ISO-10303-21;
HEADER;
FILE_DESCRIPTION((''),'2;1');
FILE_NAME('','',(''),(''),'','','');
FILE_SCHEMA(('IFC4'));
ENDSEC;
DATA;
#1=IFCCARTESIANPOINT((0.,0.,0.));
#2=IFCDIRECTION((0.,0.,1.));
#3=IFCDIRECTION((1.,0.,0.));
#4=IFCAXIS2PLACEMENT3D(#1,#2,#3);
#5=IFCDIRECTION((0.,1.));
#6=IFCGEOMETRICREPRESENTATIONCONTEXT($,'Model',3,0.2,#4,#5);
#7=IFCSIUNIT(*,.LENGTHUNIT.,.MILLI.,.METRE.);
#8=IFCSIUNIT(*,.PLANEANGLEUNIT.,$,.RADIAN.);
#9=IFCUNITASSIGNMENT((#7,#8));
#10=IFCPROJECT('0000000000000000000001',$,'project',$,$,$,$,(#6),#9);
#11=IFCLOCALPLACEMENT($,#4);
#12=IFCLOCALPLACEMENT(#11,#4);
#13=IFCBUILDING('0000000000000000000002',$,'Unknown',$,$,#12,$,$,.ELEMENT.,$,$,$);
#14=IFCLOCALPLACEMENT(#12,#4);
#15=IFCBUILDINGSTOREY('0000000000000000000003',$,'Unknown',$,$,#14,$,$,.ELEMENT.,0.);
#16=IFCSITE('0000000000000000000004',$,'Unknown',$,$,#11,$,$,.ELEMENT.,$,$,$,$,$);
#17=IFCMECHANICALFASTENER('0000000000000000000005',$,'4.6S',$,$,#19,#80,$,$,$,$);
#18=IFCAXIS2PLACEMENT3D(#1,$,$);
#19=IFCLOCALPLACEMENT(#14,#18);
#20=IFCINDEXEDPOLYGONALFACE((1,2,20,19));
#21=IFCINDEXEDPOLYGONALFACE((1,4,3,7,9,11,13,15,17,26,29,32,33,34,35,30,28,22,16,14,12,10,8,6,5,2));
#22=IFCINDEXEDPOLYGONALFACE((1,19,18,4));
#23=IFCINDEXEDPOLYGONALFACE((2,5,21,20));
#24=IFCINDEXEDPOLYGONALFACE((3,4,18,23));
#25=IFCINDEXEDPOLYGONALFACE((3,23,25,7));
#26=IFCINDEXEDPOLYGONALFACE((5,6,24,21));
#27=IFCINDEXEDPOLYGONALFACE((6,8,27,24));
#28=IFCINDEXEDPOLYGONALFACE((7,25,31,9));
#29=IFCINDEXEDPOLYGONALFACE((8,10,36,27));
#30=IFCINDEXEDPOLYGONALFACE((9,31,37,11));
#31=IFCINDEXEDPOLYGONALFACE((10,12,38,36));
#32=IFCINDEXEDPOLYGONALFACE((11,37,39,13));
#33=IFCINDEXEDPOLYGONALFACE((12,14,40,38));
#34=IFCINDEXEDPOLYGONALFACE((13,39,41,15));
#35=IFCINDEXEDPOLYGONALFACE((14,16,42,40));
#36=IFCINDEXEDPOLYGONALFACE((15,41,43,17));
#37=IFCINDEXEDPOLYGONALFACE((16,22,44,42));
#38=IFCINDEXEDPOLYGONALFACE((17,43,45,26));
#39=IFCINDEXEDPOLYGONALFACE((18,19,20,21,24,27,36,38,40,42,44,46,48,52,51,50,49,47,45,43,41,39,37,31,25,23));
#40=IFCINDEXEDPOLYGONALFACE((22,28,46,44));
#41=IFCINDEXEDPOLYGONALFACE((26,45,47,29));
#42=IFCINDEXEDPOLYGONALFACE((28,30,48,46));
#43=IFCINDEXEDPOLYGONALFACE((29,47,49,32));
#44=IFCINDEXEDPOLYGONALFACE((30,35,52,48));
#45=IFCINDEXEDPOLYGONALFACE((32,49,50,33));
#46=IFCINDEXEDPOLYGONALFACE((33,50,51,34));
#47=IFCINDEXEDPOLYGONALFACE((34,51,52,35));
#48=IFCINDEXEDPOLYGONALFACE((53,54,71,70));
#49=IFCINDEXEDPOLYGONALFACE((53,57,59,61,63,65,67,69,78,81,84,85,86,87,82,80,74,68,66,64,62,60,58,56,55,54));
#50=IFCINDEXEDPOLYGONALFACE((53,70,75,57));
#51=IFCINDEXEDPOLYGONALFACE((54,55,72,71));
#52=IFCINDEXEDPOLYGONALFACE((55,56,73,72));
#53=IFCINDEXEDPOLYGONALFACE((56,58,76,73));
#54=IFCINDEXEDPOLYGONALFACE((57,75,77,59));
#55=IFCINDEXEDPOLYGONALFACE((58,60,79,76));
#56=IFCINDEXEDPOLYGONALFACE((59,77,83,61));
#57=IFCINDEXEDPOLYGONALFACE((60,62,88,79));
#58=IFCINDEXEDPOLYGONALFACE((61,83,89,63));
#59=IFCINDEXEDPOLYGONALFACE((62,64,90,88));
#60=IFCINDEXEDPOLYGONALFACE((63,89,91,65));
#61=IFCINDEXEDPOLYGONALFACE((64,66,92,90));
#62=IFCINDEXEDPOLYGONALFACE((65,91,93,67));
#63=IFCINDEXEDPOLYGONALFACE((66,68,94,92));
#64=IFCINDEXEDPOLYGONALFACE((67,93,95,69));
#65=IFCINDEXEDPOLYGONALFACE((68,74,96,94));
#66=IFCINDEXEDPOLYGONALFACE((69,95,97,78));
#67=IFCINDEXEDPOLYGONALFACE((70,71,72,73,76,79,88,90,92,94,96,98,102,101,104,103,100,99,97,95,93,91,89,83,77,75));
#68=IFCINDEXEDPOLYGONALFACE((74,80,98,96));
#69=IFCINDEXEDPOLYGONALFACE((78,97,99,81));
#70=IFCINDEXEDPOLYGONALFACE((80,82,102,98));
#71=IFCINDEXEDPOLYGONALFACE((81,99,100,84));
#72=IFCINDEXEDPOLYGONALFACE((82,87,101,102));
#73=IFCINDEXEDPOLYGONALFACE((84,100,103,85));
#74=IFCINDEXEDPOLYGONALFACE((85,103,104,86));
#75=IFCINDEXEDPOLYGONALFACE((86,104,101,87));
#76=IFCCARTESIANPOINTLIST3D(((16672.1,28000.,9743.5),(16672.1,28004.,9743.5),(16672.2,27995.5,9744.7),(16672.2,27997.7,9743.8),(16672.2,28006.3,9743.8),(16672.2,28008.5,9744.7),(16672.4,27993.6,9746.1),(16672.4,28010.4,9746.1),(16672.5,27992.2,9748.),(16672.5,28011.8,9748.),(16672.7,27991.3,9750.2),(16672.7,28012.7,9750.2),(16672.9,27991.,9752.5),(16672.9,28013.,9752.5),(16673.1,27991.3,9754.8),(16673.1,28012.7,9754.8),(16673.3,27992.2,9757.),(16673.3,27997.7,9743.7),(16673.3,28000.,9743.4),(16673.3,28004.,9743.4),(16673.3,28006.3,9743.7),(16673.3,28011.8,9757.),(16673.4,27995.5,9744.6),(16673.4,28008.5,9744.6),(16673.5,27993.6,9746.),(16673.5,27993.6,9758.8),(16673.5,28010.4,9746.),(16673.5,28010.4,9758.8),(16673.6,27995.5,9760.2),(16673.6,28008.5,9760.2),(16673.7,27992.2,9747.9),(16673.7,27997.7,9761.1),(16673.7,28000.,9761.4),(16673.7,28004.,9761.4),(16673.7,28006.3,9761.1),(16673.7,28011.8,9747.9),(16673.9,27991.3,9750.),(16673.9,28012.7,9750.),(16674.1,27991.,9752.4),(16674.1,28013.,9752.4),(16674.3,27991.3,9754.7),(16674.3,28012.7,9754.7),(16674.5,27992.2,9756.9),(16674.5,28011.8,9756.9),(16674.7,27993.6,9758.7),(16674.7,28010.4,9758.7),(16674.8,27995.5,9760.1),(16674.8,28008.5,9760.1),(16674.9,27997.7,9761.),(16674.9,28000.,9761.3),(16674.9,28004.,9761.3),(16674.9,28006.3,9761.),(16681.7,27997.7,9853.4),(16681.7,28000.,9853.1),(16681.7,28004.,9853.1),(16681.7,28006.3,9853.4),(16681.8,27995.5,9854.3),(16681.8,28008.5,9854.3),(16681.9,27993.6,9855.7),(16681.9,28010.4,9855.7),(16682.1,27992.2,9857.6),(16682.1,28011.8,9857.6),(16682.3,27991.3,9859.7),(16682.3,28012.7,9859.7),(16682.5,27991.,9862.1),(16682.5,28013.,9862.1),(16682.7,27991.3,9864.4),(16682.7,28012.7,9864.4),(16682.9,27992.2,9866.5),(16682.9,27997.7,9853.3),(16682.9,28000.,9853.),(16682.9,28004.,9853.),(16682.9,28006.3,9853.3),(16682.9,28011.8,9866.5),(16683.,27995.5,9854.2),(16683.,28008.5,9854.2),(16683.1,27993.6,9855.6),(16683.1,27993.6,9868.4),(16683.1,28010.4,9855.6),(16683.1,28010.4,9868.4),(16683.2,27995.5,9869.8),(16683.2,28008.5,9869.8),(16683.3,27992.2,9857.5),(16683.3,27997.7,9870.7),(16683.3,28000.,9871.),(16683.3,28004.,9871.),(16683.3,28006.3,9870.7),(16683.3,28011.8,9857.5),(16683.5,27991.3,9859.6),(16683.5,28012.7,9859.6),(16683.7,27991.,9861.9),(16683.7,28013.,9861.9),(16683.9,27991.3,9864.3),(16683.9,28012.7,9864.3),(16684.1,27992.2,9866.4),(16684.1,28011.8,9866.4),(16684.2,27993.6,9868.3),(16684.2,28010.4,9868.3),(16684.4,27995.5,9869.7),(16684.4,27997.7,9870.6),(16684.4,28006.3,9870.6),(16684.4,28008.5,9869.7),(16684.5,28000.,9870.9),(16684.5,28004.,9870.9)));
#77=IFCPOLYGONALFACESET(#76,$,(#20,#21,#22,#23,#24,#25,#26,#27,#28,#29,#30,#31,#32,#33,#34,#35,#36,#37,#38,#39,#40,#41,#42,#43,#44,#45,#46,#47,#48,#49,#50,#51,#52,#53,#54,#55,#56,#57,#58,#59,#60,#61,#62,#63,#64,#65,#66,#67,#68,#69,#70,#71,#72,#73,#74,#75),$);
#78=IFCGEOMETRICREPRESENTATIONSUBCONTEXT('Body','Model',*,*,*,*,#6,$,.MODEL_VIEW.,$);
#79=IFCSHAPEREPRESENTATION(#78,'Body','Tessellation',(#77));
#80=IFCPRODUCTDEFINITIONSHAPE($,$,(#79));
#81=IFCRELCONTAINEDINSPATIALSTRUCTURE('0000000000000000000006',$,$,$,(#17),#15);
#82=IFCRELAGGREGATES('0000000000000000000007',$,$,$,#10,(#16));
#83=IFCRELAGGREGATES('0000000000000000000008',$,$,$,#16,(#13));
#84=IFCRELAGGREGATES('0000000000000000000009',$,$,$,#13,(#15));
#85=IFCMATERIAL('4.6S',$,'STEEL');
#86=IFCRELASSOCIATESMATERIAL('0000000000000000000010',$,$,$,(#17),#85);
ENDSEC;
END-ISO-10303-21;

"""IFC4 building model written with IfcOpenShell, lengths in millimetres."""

from ifc_helpers import new_model, si_unit, direction, frame, origin_with_axes, place, context, subcontext, project, spatial, line, arc, indexed_curve, outline, extrude, source, transform, mapped, material, element, save


model = new_model("IFC4")

# Units and contexts
model_context = context("Model", 3, precision=0.2, world=origin_with_axes(), true_north=direction((0.0, 1.0)))
body_context = subcontext(model_context, "Body", "Model", "MODEL_VIEW")
ifc_project = project(units=[si_unit("LENGTHUNIT", "METRE", prefix="MILLI"), si_unit("PLANEANGLEUNIT", "RADIAN")], contexts=[model_context])

# Site, building, storey
site_placement = place(None, origin_with_axes())
site = spatial("IfcSite", under=ifc_project, at=site_placement, Name="Unknown", CompositionType="ELEMENT")
building_placement = place(site_placement, origin_with_axes())
building = spatial("IfcBuilding", under=site, at=building_placement, Name="Unknown", CompositionType="ELEMENT")
storey_placement = place(building_placement, origin_with_axes())
storey = spatial("IfcBuildingStorey", under=building, at=storey_placement, Name="Unknown", CompositionType="ELEMENT", Elevation=0.0)

# Mechanical fastener
ifc_material_1 = material(Name="4.6S", Category="STEEL")
shared_shape_1 = source(origin_with_axes(), body_context, "Body", "SweptSolid", [
    extrude(outline(indexed_curve([(-2.0, 9.0), (2.0, 9.0), (2.0, 9.0), (8.4, 6.4), (11.0, 0.0), (8.4, -6.4), (2.0, -9.0), (-2.0, -9.0), (-2.8, -9.0), (-11.0, 0.0), (-8.4, 6.4)], segments=[line(1, 2, 3), arc(3, 4, 5), arc(5, 6, 7), line(7, 8), arc(8, 9, 10), arc(10, 11, 1)])), frame((0.0, 0.0, 0.6), z_axis=(0.0, 0.0, -1.0), x_axis=(0.0, 1.0, 0.0)), (0.0, 0.0, 1.0), 1.2),
])
mechanical_fastener_1_placement = place(storey_placement, frame((16673.5, 28002.0, 9752.4), z_axis=(-0.996195, 0.0, 0.087157), x_axis=(0.087157, 0.0, 0.996195)))
element("IfcMechanicalFastener", 1, at=mechanical_fastener_1_placement, inside=storey, material=ifc_material_1, Name="4.6S", context=body_context, shape_type="MappedRepresentation", body=[
    mapped(shared_shape_1, transform((0.0, 0.0, 0.0))),
    mapped(shared_shape_1, transform((110.0, 0.0, 0.0))),
])

save(model, "model.ifc")
